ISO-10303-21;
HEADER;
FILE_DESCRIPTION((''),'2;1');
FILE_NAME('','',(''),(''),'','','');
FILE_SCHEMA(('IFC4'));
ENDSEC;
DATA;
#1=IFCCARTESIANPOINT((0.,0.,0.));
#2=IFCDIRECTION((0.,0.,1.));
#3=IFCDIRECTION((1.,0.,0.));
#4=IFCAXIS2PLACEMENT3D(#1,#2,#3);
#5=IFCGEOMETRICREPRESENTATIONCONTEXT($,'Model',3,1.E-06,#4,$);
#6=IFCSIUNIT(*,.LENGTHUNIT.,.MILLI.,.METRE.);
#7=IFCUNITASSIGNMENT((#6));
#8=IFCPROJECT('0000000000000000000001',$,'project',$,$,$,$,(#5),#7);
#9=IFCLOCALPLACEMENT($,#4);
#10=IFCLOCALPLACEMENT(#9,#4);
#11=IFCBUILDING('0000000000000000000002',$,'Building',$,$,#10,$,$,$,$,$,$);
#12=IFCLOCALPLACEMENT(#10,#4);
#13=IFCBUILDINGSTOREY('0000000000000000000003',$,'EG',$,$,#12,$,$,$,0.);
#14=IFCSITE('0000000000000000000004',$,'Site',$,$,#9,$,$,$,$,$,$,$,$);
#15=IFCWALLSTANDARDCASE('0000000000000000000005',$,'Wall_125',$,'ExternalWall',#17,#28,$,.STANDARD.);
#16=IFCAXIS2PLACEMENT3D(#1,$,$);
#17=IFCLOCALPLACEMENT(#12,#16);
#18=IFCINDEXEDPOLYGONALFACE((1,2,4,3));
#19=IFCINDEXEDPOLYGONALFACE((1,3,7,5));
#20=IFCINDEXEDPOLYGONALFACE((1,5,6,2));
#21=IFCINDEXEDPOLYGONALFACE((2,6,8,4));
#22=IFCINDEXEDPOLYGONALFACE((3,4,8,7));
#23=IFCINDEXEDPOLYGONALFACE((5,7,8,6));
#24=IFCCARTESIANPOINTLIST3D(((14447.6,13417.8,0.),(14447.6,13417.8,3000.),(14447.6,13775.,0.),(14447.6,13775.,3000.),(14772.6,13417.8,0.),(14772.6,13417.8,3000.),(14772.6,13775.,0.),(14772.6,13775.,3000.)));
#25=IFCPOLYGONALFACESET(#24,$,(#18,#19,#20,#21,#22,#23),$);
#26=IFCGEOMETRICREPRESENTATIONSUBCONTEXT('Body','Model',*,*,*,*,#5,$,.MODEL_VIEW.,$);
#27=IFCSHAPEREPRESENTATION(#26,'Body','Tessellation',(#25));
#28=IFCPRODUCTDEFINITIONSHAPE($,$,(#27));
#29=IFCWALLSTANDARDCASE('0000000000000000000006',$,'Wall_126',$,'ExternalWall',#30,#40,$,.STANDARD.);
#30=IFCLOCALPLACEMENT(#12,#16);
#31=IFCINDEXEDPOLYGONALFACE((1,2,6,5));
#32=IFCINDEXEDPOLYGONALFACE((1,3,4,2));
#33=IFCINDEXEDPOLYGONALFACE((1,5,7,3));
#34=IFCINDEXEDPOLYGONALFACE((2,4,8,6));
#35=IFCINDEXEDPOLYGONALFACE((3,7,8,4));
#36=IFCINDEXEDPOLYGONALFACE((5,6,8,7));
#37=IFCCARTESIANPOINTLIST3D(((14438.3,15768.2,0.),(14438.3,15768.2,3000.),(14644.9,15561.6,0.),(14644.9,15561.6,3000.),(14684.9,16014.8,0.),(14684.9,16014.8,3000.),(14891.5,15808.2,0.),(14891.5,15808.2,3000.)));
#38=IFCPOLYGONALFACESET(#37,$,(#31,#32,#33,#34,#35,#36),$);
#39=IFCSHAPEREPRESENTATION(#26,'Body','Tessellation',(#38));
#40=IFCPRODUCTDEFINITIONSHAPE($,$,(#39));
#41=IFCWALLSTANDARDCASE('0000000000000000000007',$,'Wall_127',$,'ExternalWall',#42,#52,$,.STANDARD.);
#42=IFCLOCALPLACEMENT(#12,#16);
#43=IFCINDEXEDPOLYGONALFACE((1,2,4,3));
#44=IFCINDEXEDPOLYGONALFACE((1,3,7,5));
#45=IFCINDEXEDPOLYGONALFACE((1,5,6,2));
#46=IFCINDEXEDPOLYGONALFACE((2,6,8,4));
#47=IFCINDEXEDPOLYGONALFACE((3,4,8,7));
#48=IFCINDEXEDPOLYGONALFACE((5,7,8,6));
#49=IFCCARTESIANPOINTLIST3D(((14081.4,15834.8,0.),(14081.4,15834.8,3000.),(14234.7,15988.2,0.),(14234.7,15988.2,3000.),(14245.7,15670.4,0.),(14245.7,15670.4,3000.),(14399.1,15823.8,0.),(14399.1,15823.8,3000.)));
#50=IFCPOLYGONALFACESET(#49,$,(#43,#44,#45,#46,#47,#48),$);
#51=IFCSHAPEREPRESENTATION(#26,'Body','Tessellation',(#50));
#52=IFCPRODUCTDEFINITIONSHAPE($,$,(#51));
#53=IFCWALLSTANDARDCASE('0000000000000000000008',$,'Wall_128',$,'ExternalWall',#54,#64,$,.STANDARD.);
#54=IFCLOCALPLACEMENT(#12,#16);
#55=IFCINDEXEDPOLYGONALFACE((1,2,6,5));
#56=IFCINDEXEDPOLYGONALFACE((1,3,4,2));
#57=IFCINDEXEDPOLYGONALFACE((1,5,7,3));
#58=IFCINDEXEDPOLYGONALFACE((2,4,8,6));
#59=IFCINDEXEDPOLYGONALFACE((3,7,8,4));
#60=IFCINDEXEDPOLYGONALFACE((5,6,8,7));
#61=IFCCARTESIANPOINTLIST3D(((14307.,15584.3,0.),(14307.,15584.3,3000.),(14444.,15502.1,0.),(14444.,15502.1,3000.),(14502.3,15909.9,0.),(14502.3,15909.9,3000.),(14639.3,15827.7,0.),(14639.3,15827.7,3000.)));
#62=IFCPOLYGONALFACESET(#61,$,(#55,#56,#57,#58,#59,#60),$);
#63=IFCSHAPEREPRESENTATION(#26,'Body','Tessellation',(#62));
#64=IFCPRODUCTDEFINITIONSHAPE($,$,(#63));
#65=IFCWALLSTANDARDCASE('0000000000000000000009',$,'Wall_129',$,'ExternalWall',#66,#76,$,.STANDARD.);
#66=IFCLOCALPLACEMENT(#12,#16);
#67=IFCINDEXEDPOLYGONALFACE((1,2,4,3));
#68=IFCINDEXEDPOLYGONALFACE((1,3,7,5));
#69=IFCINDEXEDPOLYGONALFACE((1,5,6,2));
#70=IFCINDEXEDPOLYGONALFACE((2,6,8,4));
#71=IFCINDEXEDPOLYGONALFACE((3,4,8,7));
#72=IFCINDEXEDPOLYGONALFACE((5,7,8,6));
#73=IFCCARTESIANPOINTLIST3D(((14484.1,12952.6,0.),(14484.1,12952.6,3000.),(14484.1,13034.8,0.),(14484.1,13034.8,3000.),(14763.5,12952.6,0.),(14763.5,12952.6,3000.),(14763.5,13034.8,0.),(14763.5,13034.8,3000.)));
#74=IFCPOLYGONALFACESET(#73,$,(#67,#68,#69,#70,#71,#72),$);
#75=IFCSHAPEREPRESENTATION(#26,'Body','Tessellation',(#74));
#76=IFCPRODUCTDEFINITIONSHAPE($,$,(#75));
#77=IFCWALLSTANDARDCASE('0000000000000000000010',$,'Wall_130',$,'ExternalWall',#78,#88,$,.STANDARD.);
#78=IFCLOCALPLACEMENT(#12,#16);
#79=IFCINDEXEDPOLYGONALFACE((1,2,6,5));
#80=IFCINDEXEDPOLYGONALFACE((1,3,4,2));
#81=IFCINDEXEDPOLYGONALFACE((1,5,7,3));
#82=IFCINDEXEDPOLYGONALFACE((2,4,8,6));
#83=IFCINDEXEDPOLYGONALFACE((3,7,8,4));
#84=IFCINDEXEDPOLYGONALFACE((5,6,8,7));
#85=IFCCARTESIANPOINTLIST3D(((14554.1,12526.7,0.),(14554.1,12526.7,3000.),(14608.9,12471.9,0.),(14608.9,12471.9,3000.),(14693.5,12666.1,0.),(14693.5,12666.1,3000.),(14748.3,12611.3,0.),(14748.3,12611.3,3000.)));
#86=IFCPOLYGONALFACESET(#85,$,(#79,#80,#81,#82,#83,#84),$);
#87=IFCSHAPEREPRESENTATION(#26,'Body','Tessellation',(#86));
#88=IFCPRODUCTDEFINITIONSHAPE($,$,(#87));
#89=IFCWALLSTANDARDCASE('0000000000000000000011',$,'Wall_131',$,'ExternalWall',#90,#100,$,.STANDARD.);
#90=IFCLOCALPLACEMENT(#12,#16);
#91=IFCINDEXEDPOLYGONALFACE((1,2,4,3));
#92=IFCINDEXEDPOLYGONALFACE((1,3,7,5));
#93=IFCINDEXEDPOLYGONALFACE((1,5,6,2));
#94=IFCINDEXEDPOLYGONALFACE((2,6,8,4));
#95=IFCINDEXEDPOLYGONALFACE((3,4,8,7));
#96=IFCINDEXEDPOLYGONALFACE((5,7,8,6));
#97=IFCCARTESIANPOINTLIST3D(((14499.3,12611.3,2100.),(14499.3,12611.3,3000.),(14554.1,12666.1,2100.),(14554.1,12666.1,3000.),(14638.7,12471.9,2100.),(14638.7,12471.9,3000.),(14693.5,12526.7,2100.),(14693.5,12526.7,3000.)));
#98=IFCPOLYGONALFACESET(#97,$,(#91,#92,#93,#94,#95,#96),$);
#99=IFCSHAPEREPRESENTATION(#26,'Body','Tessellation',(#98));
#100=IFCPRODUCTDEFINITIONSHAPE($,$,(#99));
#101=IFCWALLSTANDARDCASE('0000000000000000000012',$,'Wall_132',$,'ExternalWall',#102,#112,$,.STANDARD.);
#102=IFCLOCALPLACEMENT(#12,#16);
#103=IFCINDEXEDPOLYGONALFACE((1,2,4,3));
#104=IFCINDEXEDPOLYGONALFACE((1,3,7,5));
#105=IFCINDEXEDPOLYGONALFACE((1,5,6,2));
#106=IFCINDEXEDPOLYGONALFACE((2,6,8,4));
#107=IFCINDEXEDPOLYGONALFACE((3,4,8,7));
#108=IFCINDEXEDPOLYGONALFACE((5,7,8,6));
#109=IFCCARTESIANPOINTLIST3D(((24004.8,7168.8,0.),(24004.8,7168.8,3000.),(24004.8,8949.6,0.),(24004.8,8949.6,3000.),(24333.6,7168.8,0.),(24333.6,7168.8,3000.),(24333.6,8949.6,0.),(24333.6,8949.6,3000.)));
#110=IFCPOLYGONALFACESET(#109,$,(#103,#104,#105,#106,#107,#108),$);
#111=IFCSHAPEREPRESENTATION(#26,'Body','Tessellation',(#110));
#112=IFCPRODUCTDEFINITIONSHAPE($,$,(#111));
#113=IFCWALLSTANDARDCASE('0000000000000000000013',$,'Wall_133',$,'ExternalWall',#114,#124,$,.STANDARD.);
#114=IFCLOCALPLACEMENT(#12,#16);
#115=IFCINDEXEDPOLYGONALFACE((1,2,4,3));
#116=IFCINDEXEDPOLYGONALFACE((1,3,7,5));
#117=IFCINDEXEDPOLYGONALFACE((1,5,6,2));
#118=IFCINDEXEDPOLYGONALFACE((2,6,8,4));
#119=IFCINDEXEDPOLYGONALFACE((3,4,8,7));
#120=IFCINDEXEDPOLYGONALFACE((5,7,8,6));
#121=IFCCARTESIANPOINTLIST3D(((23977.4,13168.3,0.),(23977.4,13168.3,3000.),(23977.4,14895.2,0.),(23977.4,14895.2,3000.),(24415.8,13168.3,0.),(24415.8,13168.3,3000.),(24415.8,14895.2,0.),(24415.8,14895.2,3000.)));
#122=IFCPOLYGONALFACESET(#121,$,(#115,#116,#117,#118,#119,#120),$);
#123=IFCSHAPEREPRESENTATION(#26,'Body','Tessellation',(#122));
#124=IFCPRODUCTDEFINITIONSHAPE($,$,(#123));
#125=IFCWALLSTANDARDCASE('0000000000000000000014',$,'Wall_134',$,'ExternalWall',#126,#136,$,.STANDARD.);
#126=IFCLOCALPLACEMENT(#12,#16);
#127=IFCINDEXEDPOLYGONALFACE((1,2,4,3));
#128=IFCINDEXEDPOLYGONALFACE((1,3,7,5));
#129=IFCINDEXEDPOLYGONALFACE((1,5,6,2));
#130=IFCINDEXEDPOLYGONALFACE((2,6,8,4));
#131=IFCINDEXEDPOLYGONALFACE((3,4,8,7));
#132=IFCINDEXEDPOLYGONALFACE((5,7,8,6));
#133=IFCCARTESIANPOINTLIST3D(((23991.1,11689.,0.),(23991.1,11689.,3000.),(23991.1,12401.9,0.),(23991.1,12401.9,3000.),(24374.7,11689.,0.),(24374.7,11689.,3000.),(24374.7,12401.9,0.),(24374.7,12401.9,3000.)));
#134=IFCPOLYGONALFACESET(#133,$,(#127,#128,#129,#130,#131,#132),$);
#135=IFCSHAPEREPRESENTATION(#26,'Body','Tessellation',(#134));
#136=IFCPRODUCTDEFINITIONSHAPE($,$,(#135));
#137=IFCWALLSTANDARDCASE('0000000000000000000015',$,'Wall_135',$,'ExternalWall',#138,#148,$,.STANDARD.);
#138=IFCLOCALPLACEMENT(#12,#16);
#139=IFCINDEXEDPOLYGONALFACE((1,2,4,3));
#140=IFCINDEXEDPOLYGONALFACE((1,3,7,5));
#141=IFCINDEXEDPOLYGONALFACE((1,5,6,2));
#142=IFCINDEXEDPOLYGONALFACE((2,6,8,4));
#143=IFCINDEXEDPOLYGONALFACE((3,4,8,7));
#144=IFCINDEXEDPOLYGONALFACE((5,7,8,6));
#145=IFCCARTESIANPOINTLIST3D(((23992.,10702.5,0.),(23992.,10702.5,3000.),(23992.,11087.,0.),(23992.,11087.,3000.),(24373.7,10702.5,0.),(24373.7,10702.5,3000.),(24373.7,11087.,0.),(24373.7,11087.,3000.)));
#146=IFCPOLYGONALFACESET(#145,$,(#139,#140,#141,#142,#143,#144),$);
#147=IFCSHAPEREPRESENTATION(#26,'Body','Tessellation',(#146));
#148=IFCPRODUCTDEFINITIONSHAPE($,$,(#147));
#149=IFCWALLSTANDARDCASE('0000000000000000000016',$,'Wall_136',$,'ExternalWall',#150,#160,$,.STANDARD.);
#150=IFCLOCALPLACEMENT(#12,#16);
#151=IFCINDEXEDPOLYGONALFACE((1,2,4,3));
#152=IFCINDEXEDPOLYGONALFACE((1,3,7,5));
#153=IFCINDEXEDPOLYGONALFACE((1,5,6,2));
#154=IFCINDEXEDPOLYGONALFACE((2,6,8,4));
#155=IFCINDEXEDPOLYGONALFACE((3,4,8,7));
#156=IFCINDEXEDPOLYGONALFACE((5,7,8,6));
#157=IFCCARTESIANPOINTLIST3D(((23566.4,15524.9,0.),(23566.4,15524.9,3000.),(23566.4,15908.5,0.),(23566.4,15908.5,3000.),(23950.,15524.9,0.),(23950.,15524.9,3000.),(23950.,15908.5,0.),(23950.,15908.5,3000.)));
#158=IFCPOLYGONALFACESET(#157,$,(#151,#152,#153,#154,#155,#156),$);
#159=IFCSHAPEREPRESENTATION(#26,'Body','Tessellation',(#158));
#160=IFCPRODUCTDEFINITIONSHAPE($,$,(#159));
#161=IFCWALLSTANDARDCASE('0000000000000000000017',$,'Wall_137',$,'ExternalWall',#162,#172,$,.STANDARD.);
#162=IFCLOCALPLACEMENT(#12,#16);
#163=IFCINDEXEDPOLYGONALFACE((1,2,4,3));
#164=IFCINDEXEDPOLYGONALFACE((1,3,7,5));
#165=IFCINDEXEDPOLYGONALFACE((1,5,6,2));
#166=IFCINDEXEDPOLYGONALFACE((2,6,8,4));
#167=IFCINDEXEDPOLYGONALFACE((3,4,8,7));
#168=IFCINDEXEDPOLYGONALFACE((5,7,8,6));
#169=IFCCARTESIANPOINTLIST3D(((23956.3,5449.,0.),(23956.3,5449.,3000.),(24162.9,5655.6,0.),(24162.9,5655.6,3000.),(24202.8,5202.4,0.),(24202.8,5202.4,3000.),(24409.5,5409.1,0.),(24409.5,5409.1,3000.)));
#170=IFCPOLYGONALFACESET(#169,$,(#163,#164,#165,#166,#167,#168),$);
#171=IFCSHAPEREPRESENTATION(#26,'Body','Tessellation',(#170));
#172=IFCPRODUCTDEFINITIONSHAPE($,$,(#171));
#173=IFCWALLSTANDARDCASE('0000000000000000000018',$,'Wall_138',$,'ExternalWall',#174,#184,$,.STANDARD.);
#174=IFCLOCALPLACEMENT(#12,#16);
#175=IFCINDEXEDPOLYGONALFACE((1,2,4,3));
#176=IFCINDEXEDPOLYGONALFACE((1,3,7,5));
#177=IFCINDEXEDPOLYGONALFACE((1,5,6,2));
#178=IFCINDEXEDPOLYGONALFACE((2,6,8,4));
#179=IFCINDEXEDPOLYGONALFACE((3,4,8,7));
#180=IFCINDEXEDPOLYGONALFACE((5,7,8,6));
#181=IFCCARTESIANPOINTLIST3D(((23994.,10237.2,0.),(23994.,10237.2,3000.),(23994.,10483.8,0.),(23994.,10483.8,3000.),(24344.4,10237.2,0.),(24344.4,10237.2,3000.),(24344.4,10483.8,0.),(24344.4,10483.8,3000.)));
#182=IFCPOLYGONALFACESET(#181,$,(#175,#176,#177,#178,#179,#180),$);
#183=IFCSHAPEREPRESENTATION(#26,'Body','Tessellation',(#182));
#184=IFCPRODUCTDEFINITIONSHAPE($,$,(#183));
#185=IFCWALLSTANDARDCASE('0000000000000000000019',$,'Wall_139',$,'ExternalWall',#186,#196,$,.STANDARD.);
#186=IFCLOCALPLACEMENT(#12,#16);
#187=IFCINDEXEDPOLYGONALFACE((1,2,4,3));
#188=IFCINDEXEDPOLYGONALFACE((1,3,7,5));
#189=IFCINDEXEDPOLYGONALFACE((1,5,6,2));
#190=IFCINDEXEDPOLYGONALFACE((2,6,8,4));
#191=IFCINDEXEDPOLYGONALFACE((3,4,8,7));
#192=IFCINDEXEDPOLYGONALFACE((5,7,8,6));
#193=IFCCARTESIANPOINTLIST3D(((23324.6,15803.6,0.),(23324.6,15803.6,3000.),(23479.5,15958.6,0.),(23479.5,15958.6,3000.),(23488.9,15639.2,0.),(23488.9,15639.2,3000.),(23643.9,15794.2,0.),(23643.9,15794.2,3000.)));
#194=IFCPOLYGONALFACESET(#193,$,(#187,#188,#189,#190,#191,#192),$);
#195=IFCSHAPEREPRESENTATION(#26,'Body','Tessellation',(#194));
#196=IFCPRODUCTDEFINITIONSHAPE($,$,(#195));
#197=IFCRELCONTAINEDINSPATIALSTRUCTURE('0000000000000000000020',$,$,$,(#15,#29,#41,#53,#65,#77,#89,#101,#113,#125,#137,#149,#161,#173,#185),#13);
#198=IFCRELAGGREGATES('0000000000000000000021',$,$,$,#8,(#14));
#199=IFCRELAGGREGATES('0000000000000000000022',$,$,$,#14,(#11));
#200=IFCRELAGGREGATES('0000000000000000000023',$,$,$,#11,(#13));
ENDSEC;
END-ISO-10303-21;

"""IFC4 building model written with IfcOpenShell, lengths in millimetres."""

from ifc_helpers import new_model, si_unit, frame, origin_with_axes, place, context, subcontext, project, spatial, rectangle, extrude, element, save


model = new_model("IFC4")

# Units and contexts
model_context = context("Model", 3, precision=1e-06, world=origin_with_axes())
body_context = subcontext(model_context, "Body", "Model", "MODEL_VIEW")
ifc_project = project(units=[si_unit("LENGTHUNIT", "METRE", prefix="MILLI")], contexts=[model_context])

# Site, building, storey
site_placement = place(None, origin_with_axes())
site = spatial("IfcSite", under=ifc_project, at=site_placement, Name="Site")
building_placement = place(site_placement, origin_with_axes())
building = spatial("IfcBuilding", under=site, at=building_placement, Name="Building")
storey_placement = place(building_placement, origin_with_axes())
storey = spatial("IfcBuildingStorey", under=building, at=storey_placement, Name="EG", Elevation=0.0)

# Walls
wall_1_placement = place(storey_placement, origin_with_axes())
element("IfcWallStandardCase", 1, at=wall_1_placement, inside=storey, Name="Wall_125", ObjectType="ExternalWall", PredefinedType="STANDARD", context=body_context, shape_type="SweptSolid", body=[
    extrude(rectangle(XDim=357.2, YDim=325.1), frame((14610.1, 13596.4, 0.0), z_axis=(0.0, 0.0, 1.0), x_axis=(0.0, -1.0, 0.0)), (0.0, 0.0, 1.0), 3000.0),
])
wall_2_placement = place(storey_placement, origin_with_axes())
element("IfcWallStandardCase", 2, at=wall_2_placement, inside=storey, Name="Wall_126", ObjectType="ExternalWall", PredefinedType="STANDARD", context=body_context, shape_type="SweptSolid", body=[
    extrude(rectangle(XDim=348.7, YDim=292.2), frame((14664.9, 15788.2, 0.0), z_axis=(0.0, 0.0, 1.0), x_axis=(0.707107, 0.707107, 0.0)), (0.0, 0.0, 1.0), 3000.0),
])
wall_3_placement = place(storey_placement, origin_with_axes())
element("IfcWallStandardCase", 3, at=wall_3_placement, inside=storey, Name="Wall_127", ObjectType="ExternalWall", PredefinedType="STANDARD", context=body_context, shape_type="SweptSolid", body=[
    extrude(rectangle(XDim=232.5, YDim=216.9), frame((14240.2, 15829.3, 0.0), z_axis=(0.0, 0.0, 1.0), x_axis=(-0.707107, 0.707107, 0.0)), (0.0, 0.0, 1.0), 3000.0),
])
wall_4_placement = place(storey_placement, origin_with_axes())
element("IfcWallStandardCase", 4, at=wall_4_placement, inside=storey, Name="Wall_128", ObjectType="ExternalWall", PredefinedType="STANDARD", context=body_context, shape_type="SweptSolid", body=[
    extrude(rectangle(XDim=159.8, YDim=379.6), frame((14473.1, 15706.0, 0.0), z_axis=(0.0, 0.0, 1.0), x_axis=(-0.857493, 0.514496, 0.0)), (0.0, 0.0, 1.0), 3000.0),
])
wall_5_placement = place(storey_placement, origin_with_axes())
element("IfcWallStandardCase", 5, at=wall_5_placement, inside=storey, Name="Wall_129", ObjectType="ExternalWall", PredefinedType="STANDARD", context=body_context, shape_type="SweptSolid", body=[
    extrude(rectangle(XDim=82.2, YDim=279.4), frame((14623.8, 12993.7, 0.0), z_axis=(0.0, 0.0, 1.0), x_axis=(0.0, -1.0, 0.0)), (0.0, 0.0, 1.0), 3000.0),
])
wall_6_placement = place(storey_placement, origin_with_axes())
element("IfcWallStandardCase", 6, at=wall_6_placement, inside=storey, Name="Wall_130", ObjectType="ExternalWall", PredefinedType="STANDARD", context=body_context, shape_type="SweptSolid", body=[
    extrude(rectangle(XDim=77.5, YDim=197.1), frame((14651.2, 12569.0, 0.0), z_axis=(0.0, 0.0, 1.0), x_axis=(0.707107, -0.707107, 0.0)), (0.0, 0.0, 1.0), 3000.0),
])

# Wall, opening
wall_7_placement = place(storey_placement, origin_with_axes())
wall_7 = element("IfcWallStandardCase", 7, at=wall_7_placement, inside=storey, Name="Wall_131", ObjectType="ExternalWall", PredefinedType="STANDARD", context=body_context, shape_type="SweptSolid", body=[
    extrude(rectangle(XDim=77.5, YDim=197.1), frame((14596.4, 12569.0, 0.0), z_axis=(0.0, 0.0, 1.0), x_axis=(-0.707107, -0.707107, 0.0)), (0.0, 0.0, 1.0), 3000.0),
])
opening_placement = place(wall_7_placement, origin_with_axes())
element("IfcOpeningElement", 8, at=opening_placement, inside=storey, cuts=wall_7, context=body_context, shape_type="SweptSolid", body=[
    extrude(rectangle(XDim=450.0, YDim=197.1), frame((14596.4, 12569.0, 0.0), z_axis=(0.0, 0.0, 1.0), x_axis=(-0.707107, -0.707107, 0.0)), (0.0, 0.0, 1.0), 2100.0),
])

# Walls
wall_8_placement = place(storey_placement, origin_with_axes())
element("IfcWallStandardCase", 9, at=wall_8_placement, inside=storey, Name="Wall_132", ObjectType="ExternalWall", PredefinedType="STANDARD", context=body_context, shape_type="SweptSolid", body=[
    extrude(rectangle(XDim=1780.8, YDim=328.8), frame((24169.2, 8059.2, 0.0), z_axis=(0.0, 0.0, 1.0), x_axis=(0.0, -1.0, 0.0)), (0.0, 0.0, 1.0), 3000.0),
])
wall_9_placement = place(storey_placement, origin_with_axes())
element("IfcWallStandardCase", 10, at=wall_9_placement, inside=storey, Name="Wall_133", ObjectType="ExternalWall", PredefinedType="STANDARD", context=body_context, shape_type="SweptSolid", body=[
    extrude(rectangle(XDim=1726.9, YDim=438.4), frame((24196.6, 14031.8, 0.0), z_axis=(0.0, 0.0, 1.0), x_axis=(0.0, 1.0, 0.0)), (0.0, 0.0, 1.0), 3000.0),
])
wall_10_placement = place(storey_placement, origin_with_axes())
element("IfcWallStandardCase", 11, at=wall_10_placement, inside=storey, Name="Wall_134", ObjectType="ExternalWall", PredefinedType="STANDARD", context=body_context, shape_type="SweptSolid", body=[
    extrude(rectangle(XDim=712.9, YDim=383.6), frame((24182.9, 12045.5, 0.0), z_axis=(0.0, 0.0, 1.0), x_axis=(0.0, -1.0, 0.0)), (0.0, 0.0, 1.0), 3000.0),
])
wall_11_placement = place(storey_placement, origin_with_axes())
element("IfcWallStandardCase", 12, at=wall_11_placement, inside=storey, Name="Wall_135", ObjectType="ExternalWall", PredefinedType="STANDARD", context=body_context, shape_type="SweptSolid", body=[
    extrude(rectangle(XDim=384.5, YDim=381.7), frame((24182.9, 10894.8, 0.0), z_axis=(0.0, 0.0, 1.0), x_axis=(0.0, -1.0, 0.0)), (0.0, 0.0, 1.0), 3000.0),
])
wall_12_placement = place(storey_placement, origin_with_axes())
element("IfcWallStandardCase", 13, at=wall_12_placement, inside=storey, Name="Wall_136", ObjectType="ExternalWall", PredefinedType="STANDARD", context=body_context, shape_type="SweptSolid", body=[
    extrude(rectangle(XDim=383.6, YDim=383.6), frame((23758.2, 15716.7, 0.0), z_axis=(0.0, 0.0, 1.0), x_axis=(-1.0, 0.0, 0.0)), (0.0, 0.0, 1.0), 3000.0),
])
wall_13_placement = place(storey_placement, origin_with_axes())
element("IfcWallStandardCase", 14, at=wall_13_placement, inside=storey, Name="Wall_137", ObjectType="ExternalWall", PredefinedType="STANDARD", context=body_context, shape_type="SweptSolid", body=[
    extrude(rectangle(XDim=348.7, YDim=292.2), frame((24182.9, 5429.0, 0.0), z_axis=(0.0, 0.0, 1.0), x_axis=(0.707107, -0.707107, 0.0)), (0.0, 0.0, 1.0), 3000.0),
])
wall_14_placement = place(storey_placement, origin_with_axes())
element("IfcWallStandardCase", 15, at=wall_14_placement, inside=storey, Name="Wall_138", ObjectType="ExternalWall", PredefinedType="STANDARD", context=body_context, shape_type="SweptSolid", body=[
    extrude(rectangle(XDim=246.6, YDim=350.3), frame((24169.2, 10360.5, 0.0), z_axis=(0.0, 0.0, 1.0), x_axis=(0.0, -1.0, 0.0)), (0.0, 0.0, 1.0), 3000.0),
])
wall_15_placement = place(storey_placement, origin_with_axes())
element("IfcWallStandardCase", 16, at=wall_15_placement, inside=storey, Name="Wall_139", ObjectType="ExternalWall", PredefinedType="STANDARD", context=body_context, shape_type="SweptSolid", body=[
    extrude(rectangle(XDim=232.5, YDim=219.2), frame((23484.2, 15798.9, 0.0), z_axis=(0.0, 0.0, 1.0), x_axis=(-0.707107, 0.707107, 0.0)), (0.0, 0.0, 1.0), 3000.0),
])

save(model, "model.ifc")
